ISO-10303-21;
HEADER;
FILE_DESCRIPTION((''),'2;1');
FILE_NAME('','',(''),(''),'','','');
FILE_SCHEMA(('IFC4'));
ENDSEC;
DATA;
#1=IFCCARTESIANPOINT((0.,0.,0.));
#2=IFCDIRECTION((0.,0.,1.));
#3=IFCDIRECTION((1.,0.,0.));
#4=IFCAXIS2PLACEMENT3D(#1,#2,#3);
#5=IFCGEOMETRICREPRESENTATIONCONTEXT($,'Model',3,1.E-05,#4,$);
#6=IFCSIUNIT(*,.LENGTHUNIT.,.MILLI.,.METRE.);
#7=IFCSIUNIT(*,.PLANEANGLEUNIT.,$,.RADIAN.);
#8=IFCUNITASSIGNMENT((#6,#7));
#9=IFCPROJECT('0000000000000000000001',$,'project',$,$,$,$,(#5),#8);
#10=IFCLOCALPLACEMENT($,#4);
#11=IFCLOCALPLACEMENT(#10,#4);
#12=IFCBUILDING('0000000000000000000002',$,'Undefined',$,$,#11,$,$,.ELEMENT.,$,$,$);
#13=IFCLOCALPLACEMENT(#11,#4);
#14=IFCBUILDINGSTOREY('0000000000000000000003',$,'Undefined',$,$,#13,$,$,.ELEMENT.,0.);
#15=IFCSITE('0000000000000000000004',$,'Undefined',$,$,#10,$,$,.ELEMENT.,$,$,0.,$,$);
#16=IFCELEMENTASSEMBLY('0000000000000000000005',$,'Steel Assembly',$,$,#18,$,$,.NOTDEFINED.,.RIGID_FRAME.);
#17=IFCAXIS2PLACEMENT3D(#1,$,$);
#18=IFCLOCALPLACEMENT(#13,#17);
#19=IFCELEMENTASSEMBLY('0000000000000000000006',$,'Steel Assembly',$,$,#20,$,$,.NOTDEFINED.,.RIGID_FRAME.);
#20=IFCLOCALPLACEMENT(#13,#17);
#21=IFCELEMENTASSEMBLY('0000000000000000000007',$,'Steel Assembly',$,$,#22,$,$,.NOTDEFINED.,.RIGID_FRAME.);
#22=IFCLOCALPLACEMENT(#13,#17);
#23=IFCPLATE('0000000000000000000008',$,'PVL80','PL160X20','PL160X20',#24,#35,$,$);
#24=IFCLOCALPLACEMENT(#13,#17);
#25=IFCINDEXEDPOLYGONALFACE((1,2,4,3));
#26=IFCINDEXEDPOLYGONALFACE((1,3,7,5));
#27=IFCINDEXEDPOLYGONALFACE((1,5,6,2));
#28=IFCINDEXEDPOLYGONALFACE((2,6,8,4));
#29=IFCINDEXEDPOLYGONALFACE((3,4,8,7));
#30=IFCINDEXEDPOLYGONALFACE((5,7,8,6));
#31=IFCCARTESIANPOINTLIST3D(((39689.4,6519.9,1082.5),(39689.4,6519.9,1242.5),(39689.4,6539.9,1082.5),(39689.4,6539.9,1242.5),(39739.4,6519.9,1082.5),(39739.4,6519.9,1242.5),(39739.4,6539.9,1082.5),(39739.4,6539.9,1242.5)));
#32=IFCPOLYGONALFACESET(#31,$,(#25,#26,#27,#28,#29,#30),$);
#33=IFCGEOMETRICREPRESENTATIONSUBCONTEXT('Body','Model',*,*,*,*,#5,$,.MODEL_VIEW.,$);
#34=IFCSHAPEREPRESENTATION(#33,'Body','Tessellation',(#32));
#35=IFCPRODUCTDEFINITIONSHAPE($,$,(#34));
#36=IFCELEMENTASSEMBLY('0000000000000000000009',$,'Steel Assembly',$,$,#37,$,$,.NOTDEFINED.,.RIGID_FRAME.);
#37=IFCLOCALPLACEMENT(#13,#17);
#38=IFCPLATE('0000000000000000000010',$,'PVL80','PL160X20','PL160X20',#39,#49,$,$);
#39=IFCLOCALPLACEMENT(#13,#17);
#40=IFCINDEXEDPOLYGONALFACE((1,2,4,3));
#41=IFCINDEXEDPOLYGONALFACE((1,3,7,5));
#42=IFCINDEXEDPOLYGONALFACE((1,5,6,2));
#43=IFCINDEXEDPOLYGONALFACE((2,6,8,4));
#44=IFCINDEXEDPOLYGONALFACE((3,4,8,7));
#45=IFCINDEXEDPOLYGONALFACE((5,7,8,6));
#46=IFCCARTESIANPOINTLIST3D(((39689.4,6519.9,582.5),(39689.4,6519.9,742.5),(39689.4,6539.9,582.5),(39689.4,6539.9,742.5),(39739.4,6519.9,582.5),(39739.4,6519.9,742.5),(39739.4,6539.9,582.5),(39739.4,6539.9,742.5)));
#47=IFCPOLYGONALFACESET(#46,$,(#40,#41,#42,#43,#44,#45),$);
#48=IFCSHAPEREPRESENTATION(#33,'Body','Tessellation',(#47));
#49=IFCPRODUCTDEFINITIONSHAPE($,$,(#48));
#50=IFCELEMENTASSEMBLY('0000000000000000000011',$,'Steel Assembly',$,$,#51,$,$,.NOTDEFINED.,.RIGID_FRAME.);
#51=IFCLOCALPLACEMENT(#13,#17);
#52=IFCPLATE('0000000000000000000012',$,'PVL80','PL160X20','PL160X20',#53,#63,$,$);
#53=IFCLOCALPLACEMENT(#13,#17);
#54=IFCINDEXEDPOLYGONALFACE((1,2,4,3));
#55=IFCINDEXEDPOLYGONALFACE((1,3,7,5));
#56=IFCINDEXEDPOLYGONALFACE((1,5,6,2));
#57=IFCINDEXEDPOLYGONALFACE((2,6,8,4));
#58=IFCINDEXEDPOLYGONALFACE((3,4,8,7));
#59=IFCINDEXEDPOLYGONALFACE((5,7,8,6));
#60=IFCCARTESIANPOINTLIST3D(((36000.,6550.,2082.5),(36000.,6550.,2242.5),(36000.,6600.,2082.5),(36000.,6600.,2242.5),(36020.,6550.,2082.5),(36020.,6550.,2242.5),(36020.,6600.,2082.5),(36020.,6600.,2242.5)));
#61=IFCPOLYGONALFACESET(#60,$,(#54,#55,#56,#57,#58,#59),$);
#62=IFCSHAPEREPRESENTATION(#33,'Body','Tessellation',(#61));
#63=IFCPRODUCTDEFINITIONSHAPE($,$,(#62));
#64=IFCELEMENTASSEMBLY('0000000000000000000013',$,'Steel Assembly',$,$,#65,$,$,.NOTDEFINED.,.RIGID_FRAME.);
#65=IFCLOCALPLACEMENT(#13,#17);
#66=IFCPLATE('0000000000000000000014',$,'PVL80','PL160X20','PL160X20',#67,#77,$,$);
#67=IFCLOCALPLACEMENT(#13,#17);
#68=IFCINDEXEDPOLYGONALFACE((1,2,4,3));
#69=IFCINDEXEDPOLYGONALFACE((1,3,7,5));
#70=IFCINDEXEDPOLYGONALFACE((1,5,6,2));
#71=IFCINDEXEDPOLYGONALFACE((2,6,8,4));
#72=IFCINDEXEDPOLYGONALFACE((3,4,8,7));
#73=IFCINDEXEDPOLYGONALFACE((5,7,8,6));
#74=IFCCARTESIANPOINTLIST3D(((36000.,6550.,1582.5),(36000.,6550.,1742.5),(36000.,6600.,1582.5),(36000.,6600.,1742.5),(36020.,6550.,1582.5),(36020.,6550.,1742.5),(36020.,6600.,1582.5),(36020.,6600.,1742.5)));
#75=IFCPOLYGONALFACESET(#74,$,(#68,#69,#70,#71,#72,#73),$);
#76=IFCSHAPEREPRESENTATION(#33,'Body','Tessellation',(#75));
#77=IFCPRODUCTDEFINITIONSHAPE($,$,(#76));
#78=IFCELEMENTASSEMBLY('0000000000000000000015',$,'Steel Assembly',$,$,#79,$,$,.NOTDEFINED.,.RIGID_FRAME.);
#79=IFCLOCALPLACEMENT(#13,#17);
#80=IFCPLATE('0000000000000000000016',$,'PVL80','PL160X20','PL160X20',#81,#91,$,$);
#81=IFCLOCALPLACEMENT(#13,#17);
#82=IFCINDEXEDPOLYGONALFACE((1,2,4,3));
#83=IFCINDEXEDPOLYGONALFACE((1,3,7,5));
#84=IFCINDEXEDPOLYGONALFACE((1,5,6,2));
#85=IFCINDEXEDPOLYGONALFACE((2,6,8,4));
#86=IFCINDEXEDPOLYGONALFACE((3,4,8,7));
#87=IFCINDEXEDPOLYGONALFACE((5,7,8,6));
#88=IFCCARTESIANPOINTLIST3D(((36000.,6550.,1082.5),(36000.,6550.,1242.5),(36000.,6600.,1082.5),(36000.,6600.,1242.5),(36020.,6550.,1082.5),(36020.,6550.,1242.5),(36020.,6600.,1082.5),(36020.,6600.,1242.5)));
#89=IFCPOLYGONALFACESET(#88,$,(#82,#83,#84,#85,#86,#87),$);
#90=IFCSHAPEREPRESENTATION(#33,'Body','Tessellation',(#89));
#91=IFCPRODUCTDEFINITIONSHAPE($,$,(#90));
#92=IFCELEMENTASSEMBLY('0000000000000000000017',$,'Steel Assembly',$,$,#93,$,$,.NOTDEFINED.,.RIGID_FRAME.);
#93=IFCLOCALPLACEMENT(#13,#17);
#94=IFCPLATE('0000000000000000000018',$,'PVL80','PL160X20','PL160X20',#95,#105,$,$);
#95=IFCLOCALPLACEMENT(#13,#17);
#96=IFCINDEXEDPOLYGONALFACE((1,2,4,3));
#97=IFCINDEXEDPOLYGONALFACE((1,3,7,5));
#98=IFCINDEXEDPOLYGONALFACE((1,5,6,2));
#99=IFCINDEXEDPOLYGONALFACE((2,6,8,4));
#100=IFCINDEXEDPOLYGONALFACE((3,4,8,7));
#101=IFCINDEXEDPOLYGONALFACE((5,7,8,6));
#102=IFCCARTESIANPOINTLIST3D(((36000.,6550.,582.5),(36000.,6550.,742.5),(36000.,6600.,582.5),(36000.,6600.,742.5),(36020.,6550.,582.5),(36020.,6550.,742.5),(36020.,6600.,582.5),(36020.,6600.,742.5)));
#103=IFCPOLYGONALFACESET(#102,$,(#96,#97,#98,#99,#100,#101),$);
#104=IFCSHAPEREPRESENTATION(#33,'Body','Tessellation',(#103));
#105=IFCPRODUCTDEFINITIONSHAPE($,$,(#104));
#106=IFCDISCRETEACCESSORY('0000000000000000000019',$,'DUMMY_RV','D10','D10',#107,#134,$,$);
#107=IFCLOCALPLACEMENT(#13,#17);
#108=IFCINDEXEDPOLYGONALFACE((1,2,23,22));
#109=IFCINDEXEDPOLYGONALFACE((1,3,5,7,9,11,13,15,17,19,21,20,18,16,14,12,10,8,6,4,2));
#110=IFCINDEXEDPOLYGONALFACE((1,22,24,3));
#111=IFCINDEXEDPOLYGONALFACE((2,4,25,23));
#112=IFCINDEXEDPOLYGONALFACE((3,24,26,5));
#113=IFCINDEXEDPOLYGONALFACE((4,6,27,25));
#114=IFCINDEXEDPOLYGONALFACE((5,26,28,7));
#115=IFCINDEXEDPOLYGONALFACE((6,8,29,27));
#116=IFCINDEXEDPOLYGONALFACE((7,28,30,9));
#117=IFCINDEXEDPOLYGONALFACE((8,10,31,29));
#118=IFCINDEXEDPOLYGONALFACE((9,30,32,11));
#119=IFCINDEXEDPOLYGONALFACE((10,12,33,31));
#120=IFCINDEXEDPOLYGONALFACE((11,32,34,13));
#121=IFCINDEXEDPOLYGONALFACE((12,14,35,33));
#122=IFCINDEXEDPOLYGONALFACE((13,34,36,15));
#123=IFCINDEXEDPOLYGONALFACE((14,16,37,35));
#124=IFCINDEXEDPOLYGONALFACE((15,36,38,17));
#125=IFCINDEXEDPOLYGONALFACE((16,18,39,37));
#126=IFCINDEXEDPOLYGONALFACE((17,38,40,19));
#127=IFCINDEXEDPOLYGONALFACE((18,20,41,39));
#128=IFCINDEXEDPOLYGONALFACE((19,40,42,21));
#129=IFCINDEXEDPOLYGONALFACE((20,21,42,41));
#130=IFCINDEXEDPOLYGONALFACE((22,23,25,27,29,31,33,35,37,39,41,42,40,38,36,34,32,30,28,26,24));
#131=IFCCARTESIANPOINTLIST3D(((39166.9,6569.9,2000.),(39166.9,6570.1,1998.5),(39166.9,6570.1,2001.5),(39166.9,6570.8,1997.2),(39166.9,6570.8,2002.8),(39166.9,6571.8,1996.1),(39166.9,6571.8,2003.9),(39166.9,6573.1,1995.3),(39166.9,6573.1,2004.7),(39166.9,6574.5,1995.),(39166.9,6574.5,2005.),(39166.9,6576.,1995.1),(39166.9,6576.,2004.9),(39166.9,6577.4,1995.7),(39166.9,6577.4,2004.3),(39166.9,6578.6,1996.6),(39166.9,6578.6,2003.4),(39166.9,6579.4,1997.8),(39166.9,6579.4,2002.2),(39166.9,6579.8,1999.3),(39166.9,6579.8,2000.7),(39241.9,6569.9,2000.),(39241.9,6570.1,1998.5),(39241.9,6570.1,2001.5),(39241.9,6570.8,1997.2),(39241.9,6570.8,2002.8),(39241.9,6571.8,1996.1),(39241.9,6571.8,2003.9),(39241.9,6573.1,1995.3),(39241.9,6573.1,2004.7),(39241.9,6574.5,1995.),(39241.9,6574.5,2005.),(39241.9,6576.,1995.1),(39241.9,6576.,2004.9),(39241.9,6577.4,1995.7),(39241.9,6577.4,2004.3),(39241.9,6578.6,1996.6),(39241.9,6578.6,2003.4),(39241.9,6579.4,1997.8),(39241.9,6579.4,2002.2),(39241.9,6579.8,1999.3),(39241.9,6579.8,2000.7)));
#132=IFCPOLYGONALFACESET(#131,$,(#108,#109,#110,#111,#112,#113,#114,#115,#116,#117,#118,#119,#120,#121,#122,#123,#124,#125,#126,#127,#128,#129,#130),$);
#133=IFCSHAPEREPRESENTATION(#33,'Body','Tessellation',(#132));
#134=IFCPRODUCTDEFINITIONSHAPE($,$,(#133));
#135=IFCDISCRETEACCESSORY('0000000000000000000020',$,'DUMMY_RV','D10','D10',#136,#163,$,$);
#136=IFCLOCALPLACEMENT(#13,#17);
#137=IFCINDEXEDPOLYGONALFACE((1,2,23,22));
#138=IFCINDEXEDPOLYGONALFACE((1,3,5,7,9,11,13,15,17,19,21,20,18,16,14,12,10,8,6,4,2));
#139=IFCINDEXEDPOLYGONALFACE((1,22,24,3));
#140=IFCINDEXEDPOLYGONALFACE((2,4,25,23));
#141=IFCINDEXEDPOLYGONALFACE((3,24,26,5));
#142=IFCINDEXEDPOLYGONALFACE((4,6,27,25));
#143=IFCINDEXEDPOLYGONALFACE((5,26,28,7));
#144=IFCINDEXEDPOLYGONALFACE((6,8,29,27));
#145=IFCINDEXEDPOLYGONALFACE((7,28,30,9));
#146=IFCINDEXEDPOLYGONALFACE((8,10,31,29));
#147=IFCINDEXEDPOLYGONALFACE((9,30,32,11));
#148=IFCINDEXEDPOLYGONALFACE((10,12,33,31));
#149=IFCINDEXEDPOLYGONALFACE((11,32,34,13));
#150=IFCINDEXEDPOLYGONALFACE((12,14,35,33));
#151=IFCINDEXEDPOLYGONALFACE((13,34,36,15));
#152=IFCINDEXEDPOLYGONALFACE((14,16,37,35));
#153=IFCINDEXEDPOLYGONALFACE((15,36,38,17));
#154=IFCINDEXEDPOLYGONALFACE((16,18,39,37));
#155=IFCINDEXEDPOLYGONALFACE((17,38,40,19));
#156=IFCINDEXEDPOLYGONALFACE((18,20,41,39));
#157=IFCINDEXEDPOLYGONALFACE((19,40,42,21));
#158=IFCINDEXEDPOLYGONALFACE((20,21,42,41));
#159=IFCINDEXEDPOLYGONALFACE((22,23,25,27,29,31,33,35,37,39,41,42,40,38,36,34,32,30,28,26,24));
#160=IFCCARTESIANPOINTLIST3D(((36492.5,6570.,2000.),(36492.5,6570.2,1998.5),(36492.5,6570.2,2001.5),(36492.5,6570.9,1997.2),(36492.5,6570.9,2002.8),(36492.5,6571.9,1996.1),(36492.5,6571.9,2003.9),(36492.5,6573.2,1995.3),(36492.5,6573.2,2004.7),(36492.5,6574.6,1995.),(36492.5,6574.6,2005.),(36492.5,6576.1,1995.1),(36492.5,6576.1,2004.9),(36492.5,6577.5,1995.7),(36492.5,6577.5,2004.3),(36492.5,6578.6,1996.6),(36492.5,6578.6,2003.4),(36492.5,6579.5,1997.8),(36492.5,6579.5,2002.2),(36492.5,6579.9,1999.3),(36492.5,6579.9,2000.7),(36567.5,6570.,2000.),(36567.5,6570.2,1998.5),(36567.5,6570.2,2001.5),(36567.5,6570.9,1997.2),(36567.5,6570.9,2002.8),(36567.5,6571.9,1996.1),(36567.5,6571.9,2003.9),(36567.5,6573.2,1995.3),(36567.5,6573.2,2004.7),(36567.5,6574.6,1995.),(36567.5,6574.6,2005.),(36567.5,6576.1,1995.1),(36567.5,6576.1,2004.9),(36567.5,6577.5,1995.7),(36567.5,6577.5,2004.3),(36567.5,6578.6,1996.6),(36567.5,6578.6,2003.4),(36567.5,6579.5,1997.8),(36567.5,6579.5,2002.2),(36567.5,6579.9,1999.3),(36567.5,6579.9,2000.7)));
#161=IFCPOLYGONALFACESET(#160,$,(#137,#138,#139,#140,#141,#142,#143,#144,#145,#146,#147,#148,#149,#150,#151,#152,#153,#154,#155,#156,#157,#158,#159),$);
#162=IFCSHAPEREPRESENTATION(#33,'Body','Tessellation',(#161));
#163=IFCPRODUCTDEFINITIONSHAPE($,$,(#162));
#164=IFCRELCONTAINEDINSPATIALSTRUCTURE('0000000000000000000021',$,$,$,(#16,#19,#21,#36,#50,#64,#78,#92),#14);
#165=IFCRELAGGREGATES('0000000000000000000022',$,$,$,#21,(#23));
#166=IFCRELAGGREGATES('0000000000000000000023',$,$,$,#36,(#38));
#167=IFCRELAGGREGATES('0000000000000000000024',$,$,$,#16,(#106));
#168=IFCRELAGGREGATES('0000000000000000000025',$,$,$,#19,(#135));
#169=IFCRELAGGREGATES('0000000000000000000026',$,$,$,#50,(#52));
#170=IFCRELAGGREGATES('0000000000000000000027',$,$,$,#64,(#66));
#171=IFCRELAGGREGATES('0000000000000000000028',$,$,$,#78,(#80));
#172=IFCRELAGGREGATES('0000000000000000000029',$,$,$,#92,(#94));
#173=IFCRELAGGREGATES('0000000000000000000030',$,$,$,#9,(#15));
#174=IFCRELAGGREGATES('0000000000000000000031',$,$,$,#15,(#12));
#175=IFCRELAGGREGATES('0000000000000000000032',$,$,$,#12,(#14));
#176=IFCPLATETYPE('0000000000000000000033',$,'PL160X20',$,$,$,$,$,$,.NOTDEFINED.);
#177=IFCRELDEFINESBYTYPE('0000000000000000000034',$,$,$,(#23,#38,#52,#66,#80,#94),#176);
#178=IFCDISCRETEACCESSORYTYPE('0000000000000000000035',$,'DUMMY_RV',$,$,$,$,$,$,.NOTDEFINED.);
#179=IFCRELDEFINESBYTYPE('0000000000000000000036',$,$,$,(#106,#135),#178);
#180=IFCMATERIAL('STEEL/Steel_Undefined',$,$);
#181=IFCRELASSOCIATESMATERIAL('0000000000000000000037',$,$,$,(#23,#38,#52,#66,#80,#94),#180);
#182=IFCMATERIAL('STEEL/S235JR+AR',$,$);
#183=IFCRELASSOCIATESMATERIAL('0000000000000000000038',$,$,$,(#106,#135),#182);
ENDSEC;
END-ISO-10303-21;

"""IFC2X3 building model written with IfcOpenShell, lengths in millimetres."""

from ifc_helpers import new_model, si_unit, frame, origin_with_axes, origin_2d_with_axis, place, context, subcontext, project, spatial, polyline, circle, outline, extrude, material, type_object, element, aggregate, save


model = new_model("IFC2X3")

# Units and contexts
model_context = context("Model", 3, precision=1e-05, world=origin_with_axes())
body_context = subcontext(model_context, "Body", "Model", "MODEL_VIEW")
ifc_project = project(units=[si_unit("LENGTHUNIT", "METRE", prefix="MILLI"), si_unit("PLANEANGLEUNIT", "RADIAN")], contexts=[model_context])

# Site, building, storey
site_placement = place(None, origin_with_axes())
site = spatial("IfcSite", under=ifc_project, at=site_placement, Name="Undefined", CompositionType="ELEMENT", RefElevation=0.0)
building_placement = place(site_placement, origin_with_axes())
building = spatial("IfcBuilding", under=site, at=building_placement, Name="Undefined", CompositionType="ELEMENT")
storey_placement = place(building_placement, origin_with_axes())
storey = spatial("IfcBuildingStorey", under=building, at=storey_placement, Name="Undefined", CompositionType="ELEMENT", Elevation=0.0)

# Element assemblies
assembly_1_placement = place(storey_placement, origin_with_axes())
assembly_1 = element("IfcElementAssembly", 1, at=assembly_1_placement, inside=storey, Name="Steel Assembly", AssemblyPlace="NOTDEFINED", PredefinedType="RIGID_FRAME")
ifc_material_1 = material(Name="STEEL/S235JR+AR")
assembly_2_placement = place(storey_placement, origin_with_axes())
assembly_2 = element("IfcElementAssembly", 2, at=assembly_2_placement, inside=storey, Name="Steel Assembly", AssemblyPlace="NOTDEFINED", PredefinedType="RIGID_FRAME")

# Element assemblies, plates
ifc_material_2 = material(Name="STEEL/Steel_Undefined")
plate_type = type_object("IfcPlateType", Name="PL160X20", PredefinedType="NOTDEFINED")
assembly_3_placement = place(storey_placement, origin_with_axes())
assembly_3 = element("IfcElementAssembly", 3, at=assembly_3_placement, inside=storey, Name="Steel Assembly", AssemblyPlace="NOTDEFINED", PredefinedType="RIGID_FRAME")
plate_1_placement = place(assembly_3_placement, frame((39739.4, 6519.9, 1162.5), z_axis=(0.0, 0.0, -1.0), x_axis=(-1.0, 0.00003, 0.0)))
plate_1 = element("IfcPlate", 4, at=plate_1_placement, type_object=plate_type, material=ifc_material_2, Name="PVL80", Description="PL160X20", ObjectType="PL160X20", context=body_context, shape_type="SweptSolid", body=[
    extrude(outline(polyline([(0.0, 0.0), (50.0, 0.0), (50.0, 20.0), (0.0, 20.0), (0.0, 0.0)])), frame((0.0, 0.0, -80.0), z_axis=(0.0, 0.0, 1.0), x_axis=(1.0, 0.0, 0.0)), (0.0, 0.0, 1.0), 160.0),
])
assembly_4_placement = place(storey_placement, origin_with_axes())
assembly_4 = element("IfcElementAssembly", 5, at=assembly_4_placement, inside=storey, Name="Steel Assembly", AssemblyPlace="NOTDEFINED", PredefinedType="RIGID_FRAME")
plate_2_placement = place(assembly_4_placement, frame((39739.4, 6519.9, 662.5), z_axis=(0.0, 0.0, -1.0), x_axis=(-1.0, 0.00003, 0.0)))
plate_2 = element("IfcPlate", 6, at=plate_2_placement, type_object=plate_type, material=ifc_material_2, Name="PVL80", Description="PL160X20", ObjectType="PL160X20", context=body_context, shape_type="SweptSolid", body=[
    extrude(outline(polyline([(0.0, 0.0), (50.0, 0.0), (50.0, 20.0), (0.0, 20.0), (0.0, 0.0)])), frame((0.0, 0.0, -80.0), z_axis=(0.0, 0.0, 1.0), x_axis=(1.0, 0.0, 0.0)), (0.0, 0.0, 1.0), 160.0),
])
assembly_5_placement = place(storey_placement, origin_with_axes())
assembly_5 = element("IfcElementAssembly", 7, at=assembly_5_placement, inside=storey, Name="Steel Assembly", AssemblyPlace="NOTDEFINED", PredefinedType="RIGID_FRAME")
plate_3_placement = place(assembly_5_placement, frame((36000.0, 6550.0, 2162.5), z_axis=(0.0, 0.0, -1.0), x_axis=(0.00003, 1.0, 0.0)))
plate_3 = element("IfcPlate", 8, at=plate_3_placement, type_object=plate_type, material=ifc_material_2, Name="PVL80", Description="PL160X20", ObjectType="PL160X20", context=body_context, shape_type="SweptSolid", body=[
    extrude(outline(polyline([(0.0, 0.0), (50.0, 0.0), (50.0, 20.0), (0.0, 20.0), (0.0, 0.0)])), frame((0.0, 0.0, -80.0), z_axis=(0.0, 0.0, 1.0), x_axis=(1.0, 0.0, 0.0)), (0.0, 0.0, 1.0), 160.0),
])
assembly_6_placement = place(storey_placement, origin_with_axes())
assembly_6 = element("IfcElementAssembly", 9, at=assembly_6_placement, inside=storey, Name="Steel Assembly", AssemblyPlace="NOTDEFINED", PredefinedType="RIGID_FRAME")
plate_4_placement = place(assembly_6_placement, frame((36000.0, 6550.0, 1662.5), z_axis=(0.0, 0.0, -1.0), x_axis=(0.00003, 1.0, 0.0)))
plate_4 = element("IfcPlate", 10, at=plate_4_placement, type_object=plate_type, material=ifc_material_2, Name="PVL80", Description="PL160X20", ObjectType="PL160X20", context=body_context, shape_type="SweptSolid", body=[
    extrude(outline(polyline([(0.0, 0.0), (50.0, 0.0), (50.0, 20.0), (0.0, 20.0), (0.0, 0.0)])), frame((0.0, 0.0, -80.0), z_axis=(0.0, 0.0, 1.0), x_axis=(1.0, 0.0, 0.0)), (0.0, 0.0, 1.0), 160.0),
])
assembly_7_placement = place(storey_placement, origin_with_axes())
assembly_7 = element("IfcElementAssembly", 11, at=assembly_7_placement, inside=storey, Name="Steel Assembly", AssemblyPlace="NOTDEFINED", PredefinedType="RIGID_FRAME")
plate_5_placement = place(assembly_7_placement, frame((36000.0, 6550.0, 1162.5), z_axis=(0.0, 0.0, -1.0), x_axis=(0.00003, 1.0, 0.0)))
plate_5 = element("IfcPlate", 12, at=plate_5_placement, type_object=plate_type, material=ifc_material_2, Name="PVL80", Description="PL160X20", ObjectType="PL160X20", context=body_context, shape_type="SweptSolid", body=[
    extrude(outline(polyline([(0.0, 0.0), (50.0, 0.0), (50.0, 20.0), (0.0, 20.0), (0.0, 0.0)])), frame((0.0, 0.0, -80.0), z_axis=(0.0, 0.0, 1.0), x_axis=(1.0, 0.0, 0.0)), (0.0, 0.0, 1.0), 160.0),
])
assembly_8_placement = place(storey_placement, origin_with_axes())
assembly_8 = element("IfcElementAssembly", 13, at=assembly_8_placement, inside=storey, Name="Steel Assembly", AssemblyPlace="NOTDEFINED", PredefinedType="RIGID_FRAME")
plate_6_placement = place(assembly_8_placement, frame((36000.0, 6550.0, 662.5), z_axis=(0.0, 0.0, -1.0), x_axis=(0.00003, 1.0, 0.0)))
plate_6 = element("IfcPlate", 14, at=plate_6_placement, type_object=plate_type, material=ifc_material_2, Name="PVL80", Description="PL160X20", ObjectType="PL160X20", context=body_context, shape_type="SweptSolid", body=[
    extrude(outline(polyline([(0.0, 0.0), (50.0, 0.0), (50.0, 20.0), (0.0, 20.0), (0.0, 0.0)])), frame((0.0, 0.0, -80.0), z_axis=(0.0, 0.0, 1.0), x_axis=(1.0, 0.0, 0.0)), (0.0, 0.0, 1.0), 160.0),
])

aggregate(assembly_3, [plate_1])
aggregate(assembly_4, [plate_2])

# Discrete accessories
discrete_accessory_type = type_object("IfcDiscreteAccessoryType", Name="DUMMY_RV")
discrete_accessory_1_placement = place(assembly_1_placement, frame((39166.9, 6574.9, 2000.0), z_axis=(0.0, 0.0, 1.0), x_axis=(1.0, -0.00003, 0.0)))
discrete_accessory_1 = element("IfcDiscreteAccessory", 15, at=discrete_accessory_1_placement, type_object=discrete_accessory_type, material=ifc_material_1, Name="DUMMY_RV", Description="D10", ObjectType="D10", context=body_context, shape_type="SweptSolid", body=[
    extrude(circle(Radius=5.0, at=origin_2d_with_axis()), frame((75.0, 0.0, 0.0), z_axis=(-1.0, 0.0, 0.0), x_axis=(0.0, -1.0, 0.0)), (0.0, 0.0, 1.0), 75.0),
])
aggregate(assembly_1, [discrete_accessory_1])
discrete_accessory_2_placement = place(assembly_2_placement, frame((36492.5, 6575.0, 2000.0), z_axis=(0.0, 0.0, 1.0), x_axis=(1.0, -0.00003, 0.0)))
discrete_accessory_2 = element("IfcDiscreteAccessory", 16, at=discrete_accessory_2_placement, type_object=discrete_accessory_type, material=ifc_material_1, Name="DUMMY_RV", Description="D10", ObjectType="D10", context=body_context, shape_type="SweptSolid", body=[
    extrude(circle(Radius=5.0, at=origin_2d_with_axis()), frame((75.0, 0.0, 0.0), z_axis=(-1.0, 0.0, 0.0), x_axis=(0.0, -1.0, 0.0)), (0.0, 0.0, 1.0), 75.0),
])
aggregate(assembly_2, [discrete_accessory_2])

aggregate(assembly_5, [plate_3])
aggregate(assembly_6, [plate_4])
aggregate(assembly_7, [plate_5])
aggregate(assembly_8, [plate_6])

save(model, "model.ifc")
